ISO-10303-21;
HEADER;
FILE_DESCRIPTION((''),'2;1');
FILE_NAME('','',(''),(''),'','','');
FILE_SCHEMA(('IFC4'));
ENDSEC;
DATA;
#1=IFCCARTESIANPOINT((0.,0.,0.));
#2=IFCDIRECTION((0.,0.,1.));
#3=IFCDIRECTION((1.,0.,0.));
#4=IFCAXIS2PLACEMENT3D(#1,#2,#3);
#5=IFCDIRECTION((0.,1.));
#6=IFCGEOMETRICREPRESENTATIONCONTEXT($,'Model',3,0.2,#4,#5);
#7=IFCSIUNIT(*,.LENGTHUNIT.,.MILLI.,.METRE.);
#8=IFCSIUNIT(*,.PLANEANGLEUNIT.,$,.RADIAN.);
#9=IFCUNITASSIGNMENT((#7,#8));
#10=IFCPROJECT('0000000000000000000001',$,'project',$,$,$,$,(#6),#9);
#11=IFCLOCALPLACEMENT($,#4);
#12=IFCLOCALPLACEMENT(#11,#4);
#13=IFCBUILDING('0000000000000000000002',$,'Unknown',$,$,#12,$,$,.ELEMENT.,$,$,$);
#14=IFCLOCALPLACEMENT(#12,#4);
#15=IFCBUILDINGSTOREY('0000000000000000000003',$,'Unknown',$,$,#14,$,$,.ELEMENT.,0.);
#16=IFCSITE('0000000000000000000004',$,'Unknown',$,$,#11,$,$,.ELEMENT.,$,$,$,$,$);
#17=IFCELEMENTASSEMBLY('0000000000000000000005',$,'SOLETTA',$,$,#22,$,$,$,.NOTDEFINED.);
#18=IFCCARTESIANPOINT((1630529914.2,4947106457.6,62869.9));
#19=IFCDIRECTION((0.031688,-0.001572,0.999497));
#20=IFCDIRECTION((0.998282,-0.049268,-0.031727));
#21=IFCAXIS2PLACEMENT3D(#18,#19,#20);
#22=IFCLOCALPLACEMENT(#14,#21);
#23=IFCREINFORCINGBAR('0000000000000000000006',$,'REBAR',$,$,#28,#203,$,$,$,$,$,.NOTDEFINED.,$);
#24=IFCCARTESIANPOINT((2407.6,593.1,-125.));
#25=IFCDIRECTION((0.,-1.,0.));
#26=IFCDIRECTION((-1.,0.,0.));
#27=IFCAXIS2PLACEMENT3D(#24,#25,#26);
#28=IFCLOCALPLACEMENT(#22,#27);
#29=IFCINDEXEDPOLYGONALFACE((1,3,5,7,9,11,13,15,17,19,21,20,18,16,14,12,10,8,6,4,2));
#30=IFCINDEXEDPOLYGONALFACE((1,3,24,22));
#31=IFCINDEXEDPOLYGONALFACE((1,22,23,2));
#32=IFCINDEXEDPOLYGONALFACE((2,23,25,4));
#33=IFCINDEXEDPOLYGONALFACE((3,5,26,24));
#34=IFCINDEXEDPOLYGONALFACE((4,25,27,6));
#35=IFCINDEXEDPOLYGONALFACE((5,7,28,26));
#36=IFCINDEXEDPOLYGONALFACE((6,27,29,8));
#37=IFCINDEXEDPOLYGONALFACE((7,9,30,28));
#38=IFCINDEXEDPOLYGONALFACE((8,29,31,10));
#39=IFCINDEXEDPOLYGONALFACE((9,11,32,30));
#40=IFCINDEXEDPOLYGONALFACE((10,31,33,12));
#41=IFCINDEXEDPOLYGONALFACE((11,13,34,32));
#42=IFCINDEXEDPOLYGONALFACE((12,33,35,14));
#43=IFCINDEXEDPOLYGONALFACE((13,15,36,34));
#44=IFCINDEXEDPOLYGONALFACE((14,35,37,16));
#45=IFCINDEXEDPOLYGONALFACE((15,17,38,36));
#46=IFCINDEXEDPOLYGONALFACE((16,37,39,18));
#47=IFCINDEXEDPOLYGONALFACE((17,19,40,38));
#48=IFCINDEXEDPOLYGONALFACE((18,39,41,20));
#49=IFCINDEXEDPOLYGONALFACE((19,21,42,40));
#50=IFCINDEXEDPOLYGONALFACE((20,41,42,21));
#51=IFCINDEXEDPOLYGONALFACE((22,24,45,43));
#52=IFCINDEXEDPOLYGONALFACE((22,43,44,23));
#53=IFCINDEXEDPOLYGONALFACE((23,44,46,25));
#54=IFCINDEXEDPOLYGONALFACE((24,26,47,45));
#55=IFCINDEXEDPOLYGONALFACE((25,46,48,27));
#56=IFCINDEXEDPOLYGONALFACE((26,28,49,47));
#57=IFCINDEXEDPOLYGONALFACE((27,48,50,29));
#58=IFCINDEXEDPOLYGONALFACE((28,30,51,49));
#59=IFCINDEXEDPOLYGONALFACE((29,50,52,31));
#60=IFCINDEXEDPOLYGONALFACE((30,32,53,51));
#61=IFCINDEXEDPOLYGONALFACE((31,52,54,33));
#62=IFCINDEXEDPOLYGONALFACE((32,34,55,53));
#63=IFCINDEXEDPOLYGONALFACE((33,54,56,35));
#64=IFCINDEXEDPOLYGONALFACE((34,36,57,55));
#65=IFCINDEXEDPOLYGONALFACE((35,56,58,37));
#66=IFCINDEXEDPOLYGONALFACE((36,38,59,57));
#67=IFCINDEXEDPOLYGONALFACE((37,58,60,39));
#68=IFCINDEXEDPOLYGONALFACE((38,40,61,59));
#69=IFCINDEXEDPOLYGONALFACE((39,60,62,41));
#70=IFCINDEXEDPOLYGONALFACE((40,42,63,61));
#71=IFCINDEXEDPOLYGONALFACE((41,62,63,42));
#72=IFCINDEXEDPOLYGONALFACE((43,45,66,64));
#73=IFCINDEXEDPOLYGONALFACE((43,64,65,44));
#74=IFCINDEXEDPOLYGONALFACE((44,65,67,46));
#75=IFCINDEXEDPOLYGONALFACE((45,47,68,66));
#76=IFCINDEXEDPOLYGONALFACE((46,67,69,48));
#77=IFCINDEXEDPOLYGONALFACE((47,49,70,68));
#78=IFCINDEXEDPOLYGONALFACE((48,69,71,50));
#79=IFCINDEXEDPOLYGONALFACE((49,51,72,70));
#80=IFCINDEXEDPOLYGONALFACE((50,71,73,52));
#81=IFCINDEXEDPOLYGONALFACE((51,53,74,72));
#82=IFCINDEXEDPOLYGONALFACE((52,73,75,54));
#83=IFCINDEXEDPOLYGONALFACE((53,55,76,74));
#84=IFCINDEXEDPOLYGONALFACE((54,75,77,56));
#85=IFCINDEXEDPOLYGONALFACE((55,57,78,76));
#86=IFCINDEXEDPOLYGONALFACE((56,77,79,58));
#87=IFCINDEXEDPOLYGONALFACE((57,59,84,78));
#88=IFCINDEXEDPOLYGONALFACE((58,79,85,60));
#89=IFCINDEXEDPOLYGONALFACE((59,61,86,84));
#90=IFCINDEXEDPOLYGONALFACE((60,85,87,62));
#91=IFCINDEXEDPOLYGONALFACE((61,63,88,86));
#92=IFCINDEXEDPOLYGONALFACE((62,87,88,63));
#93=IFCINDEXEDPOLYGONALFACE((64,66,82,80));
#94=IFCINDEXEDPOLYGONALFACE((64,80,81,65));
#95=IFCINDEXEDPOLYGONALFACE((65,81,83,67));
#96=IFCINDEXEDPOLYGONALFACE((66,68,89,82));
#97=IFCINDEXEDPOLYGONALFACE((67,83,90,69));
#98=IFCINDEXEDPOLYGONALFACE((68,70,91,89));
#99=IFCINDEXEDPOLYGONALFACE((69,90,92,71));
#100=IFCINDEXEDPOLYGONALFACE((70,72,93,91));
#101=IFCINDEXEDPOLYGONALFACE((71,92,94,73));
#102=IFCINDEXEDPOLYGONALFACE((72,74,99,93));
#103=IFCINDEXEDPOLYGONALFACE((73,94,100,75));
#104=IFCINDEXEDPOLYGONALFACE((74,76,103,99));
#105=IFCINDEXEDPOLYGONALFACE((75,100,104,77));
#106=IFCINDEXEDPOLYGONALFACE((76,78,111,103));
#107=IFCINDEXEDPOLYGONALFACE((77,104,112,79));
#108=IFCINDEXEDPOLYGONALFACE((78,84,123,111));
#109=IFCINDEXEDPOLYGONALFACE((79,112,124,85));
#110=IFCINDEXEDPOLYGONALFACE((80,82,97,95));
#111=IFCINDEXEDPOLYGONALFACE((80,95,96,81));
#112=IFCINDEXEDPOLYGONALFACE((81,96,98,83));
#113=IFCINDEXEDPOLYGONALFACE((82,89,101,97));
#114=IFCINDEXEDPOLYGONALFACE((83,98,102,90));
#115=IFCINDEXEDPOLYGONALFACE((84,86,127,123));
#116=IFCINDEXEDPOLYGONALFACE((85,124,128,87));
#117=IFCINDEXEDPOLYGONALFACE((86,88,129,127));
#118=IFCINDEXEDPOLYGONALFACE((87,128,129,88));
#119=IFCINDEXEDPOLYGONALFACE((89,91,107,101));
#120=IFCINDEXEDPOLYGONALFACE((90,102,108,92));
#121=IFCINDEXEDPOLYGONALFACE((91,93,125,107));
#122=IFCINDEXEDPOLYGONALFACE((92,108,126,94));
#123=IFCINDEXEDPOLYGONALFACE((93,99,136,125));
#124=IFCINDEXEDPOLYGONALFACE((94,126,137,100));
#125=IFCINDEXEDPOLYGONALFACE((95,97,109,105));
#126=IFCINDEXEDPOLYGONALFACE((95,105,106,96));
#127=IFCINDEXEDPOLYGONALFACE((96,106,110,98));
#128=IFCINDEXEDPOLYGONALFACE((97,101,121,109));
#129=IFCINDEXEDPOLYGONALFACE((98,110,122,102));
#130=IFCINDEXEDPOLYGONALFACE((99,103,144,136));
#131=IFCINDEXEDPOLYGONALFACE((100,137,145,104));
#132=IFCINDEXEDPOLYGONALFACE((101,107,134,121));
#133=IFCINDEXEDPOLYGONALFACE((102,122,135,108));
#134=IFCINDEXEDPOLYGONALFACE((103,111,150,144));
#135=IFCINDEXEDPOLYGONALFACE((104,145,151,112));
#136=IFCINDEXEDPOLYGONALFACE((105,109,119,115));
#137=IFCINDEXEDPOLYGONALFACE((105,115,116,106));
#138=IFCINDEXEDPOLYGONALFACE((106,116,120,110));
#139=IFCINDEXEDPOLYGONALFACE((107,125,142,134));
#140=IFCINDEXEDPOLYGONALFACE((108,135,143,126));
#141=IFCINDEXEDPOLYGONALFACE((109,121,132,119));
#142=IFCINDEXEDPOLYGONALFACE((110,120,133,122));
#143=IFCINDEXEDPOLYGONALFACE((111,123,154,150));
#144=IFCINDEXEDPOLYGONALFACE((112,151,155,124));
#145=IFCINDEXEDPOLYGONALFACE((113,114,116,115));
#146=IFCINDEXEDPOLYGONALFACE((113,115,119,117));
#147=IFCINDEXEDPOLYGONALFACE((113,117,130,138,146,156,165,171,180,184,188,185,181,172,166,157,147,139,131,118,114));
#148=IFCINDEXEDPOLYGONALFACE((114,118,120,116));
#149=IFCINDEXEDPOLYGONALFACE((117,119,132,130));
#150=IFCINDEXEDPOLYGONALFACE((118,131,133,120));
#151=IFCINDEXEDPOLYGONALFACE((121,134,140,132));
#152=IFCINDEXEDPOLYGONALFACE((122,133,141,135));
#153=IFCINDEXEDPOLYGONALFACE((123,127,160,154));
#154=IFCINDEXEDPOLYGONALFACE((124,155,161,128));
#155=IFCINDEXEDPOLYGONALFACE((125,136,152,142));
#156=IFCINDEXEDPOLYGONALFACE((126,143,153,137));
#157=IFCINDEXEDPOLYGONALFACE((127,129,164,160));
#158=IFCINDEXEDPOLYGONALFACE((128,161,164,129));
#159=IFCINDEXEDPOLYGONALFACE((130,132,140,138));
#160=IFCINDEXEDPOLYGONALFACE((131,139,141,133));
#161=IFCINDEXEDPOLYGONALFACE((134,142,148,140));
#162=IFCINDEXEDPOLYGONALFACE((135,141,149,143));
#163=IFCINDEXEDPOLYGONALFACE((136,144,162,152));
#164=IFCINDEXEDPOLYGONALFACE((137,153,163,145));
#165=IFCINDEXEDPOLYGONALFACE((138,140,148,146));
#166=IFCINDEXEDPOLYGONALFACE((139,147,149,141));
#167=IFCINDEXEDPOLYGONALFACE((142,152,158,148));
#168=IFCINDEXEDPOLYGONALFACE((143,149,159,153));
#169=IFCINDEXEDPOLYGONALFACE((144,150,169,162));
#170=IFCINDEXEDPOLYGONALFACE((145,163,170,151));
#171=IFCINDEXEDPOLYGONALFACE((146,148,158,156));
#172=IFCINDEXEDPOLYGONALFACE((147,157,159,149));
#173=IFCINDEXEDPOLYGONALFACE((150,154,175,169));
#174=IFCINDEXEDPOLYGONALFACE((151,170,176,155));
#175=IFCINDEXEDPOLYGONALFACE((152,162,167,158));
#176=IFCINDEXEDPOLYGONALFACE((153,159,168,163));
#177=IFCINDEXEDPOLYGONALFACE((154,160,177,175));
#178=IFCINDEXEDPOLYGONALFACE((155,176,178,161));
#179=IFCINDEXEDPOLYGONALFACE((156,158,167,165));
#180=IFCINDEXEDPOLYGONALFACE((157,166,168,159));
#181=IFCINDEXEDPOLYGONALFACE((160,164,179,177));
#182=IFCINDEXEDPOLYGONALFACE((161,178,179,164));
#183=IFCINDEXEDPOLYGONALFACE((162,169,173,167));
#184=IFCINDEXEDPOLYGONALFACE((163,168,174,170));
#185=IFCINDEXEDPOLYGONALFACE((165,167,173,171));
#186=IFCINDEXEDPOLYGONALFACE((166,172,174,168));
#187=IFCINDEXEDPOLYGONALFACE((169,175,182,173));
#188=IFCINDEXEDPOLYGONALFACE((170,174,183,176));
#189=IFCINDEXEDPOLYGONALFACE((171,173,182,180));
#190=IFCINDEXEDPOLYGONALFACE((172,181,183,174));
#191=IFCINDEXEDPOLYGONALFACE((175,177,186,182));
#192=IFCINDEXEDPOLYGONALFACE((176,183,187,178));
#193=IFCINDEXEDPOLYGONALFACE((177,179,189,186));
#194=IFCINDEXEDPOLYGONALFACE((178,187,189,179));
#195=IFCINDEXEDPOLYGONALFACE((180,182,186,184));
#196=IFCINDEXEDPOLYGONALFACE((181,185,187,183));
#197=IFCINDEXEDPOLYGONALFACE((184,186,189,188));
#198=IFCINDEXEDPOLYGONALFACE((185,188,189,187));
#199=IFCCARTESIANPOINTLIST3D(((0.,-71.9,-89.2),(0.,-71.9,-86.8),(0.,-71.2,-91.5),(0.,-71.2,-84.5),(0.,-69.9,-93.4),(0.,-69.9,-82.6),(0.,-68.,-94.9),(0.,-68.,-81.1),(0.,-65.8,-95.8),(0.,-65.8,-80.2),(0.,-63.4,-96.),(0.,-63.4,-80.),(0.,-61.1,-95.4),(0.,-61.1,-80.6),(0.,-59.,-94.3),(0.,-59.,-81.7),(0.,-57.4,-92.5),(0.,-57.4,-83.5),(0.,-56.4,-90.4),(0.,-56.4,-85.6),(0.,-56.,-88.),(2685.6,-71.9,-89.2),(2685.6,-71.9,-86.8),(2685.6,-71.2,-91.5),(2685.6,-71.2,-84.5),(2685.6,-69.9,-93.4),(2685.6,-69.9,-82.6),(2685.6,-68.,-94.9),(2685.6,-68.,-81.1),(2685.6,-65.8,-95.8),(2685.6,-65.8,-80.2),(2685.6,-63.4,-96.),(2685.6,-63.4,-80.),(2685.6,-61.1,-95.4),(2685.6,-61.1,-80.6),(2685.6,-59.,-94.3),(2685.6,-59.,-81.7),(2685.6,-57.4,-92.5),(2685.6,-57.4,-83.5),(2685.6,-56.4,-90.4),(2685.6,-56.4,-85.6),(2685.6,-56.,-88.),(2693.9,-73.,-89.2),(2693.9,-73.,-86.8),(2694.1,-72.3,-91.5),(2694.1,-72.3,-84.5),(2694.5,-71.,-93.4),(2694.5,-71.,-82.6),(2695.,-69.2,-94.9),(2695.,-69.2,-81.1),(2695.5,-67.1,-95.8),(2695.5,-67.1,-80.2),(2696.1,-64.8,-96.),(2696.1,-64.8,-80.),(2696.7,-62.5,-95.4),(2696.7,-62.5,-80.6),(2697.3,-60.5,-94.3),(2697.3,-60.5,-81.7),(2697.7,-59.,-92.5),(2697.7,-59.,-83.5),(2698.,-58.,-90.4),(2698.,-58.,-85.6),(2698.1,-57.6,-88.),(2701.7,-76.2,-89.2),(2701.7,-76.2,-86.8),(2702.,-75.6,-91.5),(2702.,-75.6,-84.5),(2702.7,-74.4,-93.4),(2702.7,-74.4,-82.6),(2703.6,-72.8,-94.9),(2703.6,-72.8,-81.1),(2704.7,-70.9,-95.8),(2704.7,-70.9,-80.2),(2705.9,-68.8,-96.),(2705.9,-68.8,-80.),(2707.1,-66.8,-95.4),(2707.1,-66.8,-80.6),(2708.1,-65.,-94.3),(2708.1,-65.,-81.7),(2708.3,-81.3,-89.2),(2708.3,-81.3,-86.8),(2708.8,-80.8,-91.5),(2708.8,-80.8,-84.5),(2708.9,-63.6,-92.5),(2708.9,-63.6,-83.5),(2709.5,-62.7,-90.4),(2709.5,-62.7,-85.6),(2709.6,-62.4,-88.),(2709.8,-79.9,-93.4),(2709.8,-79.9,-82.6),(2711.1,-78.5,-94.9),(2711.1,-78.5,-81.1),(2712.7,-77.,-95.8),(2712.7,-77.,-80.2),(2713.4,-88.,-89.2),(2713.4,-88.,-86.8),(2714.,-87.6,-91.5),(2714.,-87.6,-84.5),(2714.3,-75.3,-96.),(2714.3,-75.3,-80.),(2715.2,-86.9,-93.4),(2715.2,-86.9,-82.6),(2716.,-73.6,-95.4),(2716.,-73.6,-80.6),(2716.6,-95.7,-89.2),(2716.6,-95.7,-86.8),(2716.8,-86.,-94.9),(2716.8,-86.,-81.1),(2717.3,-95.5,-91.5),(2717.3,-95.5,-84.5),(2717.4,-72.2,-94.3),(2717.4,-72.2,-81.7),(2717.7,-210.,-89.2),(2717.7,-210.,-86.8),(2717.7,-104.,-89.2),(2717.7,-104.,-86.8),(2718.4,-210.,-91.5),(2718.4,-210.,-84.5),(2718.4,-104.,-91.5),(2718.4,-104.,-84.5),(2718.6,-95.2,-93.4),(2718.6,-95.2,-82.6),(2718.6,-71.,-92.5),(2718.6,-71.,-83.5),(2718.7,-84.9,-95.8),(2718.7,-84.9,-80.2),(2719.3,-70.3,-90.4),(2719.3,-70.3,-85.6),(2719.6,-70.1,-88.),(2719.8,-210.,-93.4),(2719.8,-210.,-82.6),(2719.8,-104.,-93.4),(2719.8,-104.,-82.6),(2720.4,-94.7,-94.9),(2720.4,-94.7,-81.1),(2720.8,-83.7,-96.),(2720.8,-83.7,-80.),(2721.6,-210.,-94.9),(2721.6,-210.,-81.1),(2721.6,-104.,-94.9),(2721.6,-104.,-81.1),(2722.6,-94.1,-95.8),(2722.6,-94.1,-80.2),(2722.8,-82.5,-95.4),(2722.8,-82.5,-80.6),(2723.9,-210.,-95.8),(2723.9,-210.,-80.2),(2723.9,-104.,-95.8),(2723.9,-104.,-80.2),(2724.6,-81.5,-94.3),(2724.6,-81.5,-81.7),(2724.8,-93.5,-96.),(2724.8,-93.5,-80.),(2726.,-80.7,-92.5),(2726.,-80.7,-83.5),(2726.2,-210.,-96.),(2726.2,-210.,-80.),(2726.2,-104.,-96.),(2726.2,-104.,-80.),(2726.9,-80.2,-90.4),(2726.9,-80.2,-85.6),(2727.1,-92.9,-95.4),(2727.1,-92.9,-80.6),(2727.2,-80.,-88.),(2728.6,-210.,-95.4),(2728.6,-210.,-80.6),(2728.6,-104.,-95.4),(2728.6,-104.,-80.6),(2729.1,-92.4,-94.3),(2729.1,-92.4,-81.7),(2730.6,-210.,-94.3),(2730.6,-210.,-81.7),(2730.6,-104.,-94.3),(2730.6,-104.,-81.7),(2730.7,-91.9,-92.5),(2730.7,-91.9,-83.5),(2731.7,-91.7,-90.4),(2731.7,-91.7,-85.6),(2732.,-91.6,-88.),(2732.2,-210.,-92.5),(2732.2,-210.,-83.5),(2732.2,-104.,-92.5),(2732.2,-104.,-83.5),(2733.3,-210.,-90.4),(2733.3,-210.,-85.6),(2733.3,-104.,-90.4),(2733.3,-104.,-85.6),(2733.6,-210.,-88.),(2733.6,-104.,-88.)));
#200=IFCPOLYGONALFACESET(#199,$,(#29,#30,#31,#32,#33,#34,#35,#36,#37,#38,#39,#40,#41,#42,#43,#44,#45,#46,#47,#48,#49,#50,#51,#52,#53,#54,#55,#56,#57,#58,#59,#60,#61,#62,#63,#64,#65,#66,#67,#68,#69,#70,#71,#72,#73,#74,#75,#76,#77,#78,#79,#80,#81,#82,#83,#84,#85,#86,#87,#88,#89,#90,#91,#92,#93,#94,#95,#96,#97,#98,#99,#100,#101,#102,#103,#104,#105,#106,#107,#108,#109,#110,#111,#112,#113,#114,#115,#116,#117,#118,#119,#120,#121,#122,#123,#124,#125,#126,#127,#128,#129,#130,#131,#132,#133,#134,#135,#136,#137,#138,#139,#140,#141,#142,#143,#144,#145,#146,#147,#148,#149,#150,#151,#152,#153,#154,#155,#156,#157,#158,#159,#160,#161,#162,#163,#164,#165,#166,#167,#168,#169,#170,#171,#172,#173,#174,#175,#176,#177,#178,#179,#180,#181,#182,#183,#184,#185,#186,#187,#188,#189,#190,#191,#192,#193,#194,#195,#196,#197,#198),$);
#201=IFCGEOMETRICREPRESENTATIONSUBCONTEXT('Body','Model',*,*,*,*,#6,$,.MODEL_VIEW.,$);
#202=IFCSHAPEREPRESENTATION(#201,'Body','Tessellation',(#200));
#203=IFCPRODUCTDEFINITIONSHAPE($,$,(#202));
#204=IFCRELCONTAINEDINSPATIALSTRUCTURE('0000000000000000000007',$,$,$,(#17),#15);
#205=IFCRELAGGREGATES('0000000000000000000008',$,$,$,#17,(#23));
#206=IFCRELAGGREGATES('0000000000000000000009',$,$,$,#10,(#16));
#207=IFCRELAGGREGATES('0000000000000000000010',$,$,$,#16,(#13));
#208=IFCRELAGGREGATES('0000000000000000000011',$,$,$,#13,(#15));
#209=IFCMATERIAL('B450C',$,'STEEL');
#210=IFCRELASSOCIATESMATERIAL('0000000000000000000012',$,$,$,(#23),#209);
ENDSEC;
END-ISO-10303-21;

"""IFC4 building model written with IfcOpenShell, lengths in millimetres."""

from ifc_helpers import new_model, entity, si_unit, direction, frame, origin_with_axes, place, context, subcontext, project, spatial, material, element, aggregate, save


model = new_model("IFC4")

# Units and contexts
model_context = context("Model", 3, precision=0.2, world=origin_with_axes(), true_north=direction((0.0, 1.0)))
body_context = subcontext(model_context, "Body", "Model", "MODEL_VIEW")
ifc_project = project(units=[si_unit("LENGTHUNIT", "METRE", prefix="MILLI"), si_unit("PLANEANGLEUNIT", "RADIAN")], contexts=[model_context])

# Site, building, storey
site_placement = place(None, origin_with_axes())
site = spatial("IfcSite", under=ifc_project, at=site_placement, Name="Unknown", CompositionType="ELEMENT")
building_placement = place(site_placement, origin_with_axes())
building = spatial("IfcBuilding", under=site, at=building_placement, Name="Unknown", CompositionType="ELEMENT")
storey_placement = place(building_placement, origin_with_axes())
storey = spatial("IfcBuildingStorey", under=building, at=storey_placement, Name="Unknown", CompositionType="ELEMENT", Elevation=0.0)

# Element assembly
ifc_material = material(Name="B450C", Category="STEEL")
assembly_1_placement = place(storey_placement, frame((1630529914.2, 4947106457.6, 62869.9), z_axis=(0.031688, -0.001572, 0.999497), x_axis=(0.998282, -0.049268, -0.031727)))
assembly_1 = element("IfcElementAssembly", 1, at=assembly_1_placement, inside=storey, Name="SOLETTA", PredefinedType="NOTDEFINED")

# Reinforcing bar
reinforcing_bar_1_placement = place(assembly_1_placement, frame((2407.6, 593.1, -125.0), z_axis=(0.0, -1.0, 0.0), x_axis=(-1.0, 0.0, 0.0)))
reinforcing_bar_1 = element("IfcReinforcingBar", 2, at=reinforcing_bar_1_placement, material=ifc_material, Name="REBAR", PredefinedType="NOTDEFINED", context=body_context, shape_type="AdvancedSweptSolid", body=[
    entity("IfcSweptDiskSolid", entity("IfcIndexedPolyCurve", entity("IfcCartesianPointList3D", [[0.0, -64.0, -88.0], [2685.6, -64.0, -88.0], [2713.9, -75.7, -88.0], [2725.6, -104.0, -88.0], [2725.6, -210.0, -88.0]]), [entity("IfcLineIndex", [1, 2]), entity("IfcArcIndex", [2, 3, 4]), entity("IfcLineIndex", [4, 5])]), 8.0),
])
aggregate(assembly_1, [reinforcing_bar_1])

save(model, "model.ifc")
